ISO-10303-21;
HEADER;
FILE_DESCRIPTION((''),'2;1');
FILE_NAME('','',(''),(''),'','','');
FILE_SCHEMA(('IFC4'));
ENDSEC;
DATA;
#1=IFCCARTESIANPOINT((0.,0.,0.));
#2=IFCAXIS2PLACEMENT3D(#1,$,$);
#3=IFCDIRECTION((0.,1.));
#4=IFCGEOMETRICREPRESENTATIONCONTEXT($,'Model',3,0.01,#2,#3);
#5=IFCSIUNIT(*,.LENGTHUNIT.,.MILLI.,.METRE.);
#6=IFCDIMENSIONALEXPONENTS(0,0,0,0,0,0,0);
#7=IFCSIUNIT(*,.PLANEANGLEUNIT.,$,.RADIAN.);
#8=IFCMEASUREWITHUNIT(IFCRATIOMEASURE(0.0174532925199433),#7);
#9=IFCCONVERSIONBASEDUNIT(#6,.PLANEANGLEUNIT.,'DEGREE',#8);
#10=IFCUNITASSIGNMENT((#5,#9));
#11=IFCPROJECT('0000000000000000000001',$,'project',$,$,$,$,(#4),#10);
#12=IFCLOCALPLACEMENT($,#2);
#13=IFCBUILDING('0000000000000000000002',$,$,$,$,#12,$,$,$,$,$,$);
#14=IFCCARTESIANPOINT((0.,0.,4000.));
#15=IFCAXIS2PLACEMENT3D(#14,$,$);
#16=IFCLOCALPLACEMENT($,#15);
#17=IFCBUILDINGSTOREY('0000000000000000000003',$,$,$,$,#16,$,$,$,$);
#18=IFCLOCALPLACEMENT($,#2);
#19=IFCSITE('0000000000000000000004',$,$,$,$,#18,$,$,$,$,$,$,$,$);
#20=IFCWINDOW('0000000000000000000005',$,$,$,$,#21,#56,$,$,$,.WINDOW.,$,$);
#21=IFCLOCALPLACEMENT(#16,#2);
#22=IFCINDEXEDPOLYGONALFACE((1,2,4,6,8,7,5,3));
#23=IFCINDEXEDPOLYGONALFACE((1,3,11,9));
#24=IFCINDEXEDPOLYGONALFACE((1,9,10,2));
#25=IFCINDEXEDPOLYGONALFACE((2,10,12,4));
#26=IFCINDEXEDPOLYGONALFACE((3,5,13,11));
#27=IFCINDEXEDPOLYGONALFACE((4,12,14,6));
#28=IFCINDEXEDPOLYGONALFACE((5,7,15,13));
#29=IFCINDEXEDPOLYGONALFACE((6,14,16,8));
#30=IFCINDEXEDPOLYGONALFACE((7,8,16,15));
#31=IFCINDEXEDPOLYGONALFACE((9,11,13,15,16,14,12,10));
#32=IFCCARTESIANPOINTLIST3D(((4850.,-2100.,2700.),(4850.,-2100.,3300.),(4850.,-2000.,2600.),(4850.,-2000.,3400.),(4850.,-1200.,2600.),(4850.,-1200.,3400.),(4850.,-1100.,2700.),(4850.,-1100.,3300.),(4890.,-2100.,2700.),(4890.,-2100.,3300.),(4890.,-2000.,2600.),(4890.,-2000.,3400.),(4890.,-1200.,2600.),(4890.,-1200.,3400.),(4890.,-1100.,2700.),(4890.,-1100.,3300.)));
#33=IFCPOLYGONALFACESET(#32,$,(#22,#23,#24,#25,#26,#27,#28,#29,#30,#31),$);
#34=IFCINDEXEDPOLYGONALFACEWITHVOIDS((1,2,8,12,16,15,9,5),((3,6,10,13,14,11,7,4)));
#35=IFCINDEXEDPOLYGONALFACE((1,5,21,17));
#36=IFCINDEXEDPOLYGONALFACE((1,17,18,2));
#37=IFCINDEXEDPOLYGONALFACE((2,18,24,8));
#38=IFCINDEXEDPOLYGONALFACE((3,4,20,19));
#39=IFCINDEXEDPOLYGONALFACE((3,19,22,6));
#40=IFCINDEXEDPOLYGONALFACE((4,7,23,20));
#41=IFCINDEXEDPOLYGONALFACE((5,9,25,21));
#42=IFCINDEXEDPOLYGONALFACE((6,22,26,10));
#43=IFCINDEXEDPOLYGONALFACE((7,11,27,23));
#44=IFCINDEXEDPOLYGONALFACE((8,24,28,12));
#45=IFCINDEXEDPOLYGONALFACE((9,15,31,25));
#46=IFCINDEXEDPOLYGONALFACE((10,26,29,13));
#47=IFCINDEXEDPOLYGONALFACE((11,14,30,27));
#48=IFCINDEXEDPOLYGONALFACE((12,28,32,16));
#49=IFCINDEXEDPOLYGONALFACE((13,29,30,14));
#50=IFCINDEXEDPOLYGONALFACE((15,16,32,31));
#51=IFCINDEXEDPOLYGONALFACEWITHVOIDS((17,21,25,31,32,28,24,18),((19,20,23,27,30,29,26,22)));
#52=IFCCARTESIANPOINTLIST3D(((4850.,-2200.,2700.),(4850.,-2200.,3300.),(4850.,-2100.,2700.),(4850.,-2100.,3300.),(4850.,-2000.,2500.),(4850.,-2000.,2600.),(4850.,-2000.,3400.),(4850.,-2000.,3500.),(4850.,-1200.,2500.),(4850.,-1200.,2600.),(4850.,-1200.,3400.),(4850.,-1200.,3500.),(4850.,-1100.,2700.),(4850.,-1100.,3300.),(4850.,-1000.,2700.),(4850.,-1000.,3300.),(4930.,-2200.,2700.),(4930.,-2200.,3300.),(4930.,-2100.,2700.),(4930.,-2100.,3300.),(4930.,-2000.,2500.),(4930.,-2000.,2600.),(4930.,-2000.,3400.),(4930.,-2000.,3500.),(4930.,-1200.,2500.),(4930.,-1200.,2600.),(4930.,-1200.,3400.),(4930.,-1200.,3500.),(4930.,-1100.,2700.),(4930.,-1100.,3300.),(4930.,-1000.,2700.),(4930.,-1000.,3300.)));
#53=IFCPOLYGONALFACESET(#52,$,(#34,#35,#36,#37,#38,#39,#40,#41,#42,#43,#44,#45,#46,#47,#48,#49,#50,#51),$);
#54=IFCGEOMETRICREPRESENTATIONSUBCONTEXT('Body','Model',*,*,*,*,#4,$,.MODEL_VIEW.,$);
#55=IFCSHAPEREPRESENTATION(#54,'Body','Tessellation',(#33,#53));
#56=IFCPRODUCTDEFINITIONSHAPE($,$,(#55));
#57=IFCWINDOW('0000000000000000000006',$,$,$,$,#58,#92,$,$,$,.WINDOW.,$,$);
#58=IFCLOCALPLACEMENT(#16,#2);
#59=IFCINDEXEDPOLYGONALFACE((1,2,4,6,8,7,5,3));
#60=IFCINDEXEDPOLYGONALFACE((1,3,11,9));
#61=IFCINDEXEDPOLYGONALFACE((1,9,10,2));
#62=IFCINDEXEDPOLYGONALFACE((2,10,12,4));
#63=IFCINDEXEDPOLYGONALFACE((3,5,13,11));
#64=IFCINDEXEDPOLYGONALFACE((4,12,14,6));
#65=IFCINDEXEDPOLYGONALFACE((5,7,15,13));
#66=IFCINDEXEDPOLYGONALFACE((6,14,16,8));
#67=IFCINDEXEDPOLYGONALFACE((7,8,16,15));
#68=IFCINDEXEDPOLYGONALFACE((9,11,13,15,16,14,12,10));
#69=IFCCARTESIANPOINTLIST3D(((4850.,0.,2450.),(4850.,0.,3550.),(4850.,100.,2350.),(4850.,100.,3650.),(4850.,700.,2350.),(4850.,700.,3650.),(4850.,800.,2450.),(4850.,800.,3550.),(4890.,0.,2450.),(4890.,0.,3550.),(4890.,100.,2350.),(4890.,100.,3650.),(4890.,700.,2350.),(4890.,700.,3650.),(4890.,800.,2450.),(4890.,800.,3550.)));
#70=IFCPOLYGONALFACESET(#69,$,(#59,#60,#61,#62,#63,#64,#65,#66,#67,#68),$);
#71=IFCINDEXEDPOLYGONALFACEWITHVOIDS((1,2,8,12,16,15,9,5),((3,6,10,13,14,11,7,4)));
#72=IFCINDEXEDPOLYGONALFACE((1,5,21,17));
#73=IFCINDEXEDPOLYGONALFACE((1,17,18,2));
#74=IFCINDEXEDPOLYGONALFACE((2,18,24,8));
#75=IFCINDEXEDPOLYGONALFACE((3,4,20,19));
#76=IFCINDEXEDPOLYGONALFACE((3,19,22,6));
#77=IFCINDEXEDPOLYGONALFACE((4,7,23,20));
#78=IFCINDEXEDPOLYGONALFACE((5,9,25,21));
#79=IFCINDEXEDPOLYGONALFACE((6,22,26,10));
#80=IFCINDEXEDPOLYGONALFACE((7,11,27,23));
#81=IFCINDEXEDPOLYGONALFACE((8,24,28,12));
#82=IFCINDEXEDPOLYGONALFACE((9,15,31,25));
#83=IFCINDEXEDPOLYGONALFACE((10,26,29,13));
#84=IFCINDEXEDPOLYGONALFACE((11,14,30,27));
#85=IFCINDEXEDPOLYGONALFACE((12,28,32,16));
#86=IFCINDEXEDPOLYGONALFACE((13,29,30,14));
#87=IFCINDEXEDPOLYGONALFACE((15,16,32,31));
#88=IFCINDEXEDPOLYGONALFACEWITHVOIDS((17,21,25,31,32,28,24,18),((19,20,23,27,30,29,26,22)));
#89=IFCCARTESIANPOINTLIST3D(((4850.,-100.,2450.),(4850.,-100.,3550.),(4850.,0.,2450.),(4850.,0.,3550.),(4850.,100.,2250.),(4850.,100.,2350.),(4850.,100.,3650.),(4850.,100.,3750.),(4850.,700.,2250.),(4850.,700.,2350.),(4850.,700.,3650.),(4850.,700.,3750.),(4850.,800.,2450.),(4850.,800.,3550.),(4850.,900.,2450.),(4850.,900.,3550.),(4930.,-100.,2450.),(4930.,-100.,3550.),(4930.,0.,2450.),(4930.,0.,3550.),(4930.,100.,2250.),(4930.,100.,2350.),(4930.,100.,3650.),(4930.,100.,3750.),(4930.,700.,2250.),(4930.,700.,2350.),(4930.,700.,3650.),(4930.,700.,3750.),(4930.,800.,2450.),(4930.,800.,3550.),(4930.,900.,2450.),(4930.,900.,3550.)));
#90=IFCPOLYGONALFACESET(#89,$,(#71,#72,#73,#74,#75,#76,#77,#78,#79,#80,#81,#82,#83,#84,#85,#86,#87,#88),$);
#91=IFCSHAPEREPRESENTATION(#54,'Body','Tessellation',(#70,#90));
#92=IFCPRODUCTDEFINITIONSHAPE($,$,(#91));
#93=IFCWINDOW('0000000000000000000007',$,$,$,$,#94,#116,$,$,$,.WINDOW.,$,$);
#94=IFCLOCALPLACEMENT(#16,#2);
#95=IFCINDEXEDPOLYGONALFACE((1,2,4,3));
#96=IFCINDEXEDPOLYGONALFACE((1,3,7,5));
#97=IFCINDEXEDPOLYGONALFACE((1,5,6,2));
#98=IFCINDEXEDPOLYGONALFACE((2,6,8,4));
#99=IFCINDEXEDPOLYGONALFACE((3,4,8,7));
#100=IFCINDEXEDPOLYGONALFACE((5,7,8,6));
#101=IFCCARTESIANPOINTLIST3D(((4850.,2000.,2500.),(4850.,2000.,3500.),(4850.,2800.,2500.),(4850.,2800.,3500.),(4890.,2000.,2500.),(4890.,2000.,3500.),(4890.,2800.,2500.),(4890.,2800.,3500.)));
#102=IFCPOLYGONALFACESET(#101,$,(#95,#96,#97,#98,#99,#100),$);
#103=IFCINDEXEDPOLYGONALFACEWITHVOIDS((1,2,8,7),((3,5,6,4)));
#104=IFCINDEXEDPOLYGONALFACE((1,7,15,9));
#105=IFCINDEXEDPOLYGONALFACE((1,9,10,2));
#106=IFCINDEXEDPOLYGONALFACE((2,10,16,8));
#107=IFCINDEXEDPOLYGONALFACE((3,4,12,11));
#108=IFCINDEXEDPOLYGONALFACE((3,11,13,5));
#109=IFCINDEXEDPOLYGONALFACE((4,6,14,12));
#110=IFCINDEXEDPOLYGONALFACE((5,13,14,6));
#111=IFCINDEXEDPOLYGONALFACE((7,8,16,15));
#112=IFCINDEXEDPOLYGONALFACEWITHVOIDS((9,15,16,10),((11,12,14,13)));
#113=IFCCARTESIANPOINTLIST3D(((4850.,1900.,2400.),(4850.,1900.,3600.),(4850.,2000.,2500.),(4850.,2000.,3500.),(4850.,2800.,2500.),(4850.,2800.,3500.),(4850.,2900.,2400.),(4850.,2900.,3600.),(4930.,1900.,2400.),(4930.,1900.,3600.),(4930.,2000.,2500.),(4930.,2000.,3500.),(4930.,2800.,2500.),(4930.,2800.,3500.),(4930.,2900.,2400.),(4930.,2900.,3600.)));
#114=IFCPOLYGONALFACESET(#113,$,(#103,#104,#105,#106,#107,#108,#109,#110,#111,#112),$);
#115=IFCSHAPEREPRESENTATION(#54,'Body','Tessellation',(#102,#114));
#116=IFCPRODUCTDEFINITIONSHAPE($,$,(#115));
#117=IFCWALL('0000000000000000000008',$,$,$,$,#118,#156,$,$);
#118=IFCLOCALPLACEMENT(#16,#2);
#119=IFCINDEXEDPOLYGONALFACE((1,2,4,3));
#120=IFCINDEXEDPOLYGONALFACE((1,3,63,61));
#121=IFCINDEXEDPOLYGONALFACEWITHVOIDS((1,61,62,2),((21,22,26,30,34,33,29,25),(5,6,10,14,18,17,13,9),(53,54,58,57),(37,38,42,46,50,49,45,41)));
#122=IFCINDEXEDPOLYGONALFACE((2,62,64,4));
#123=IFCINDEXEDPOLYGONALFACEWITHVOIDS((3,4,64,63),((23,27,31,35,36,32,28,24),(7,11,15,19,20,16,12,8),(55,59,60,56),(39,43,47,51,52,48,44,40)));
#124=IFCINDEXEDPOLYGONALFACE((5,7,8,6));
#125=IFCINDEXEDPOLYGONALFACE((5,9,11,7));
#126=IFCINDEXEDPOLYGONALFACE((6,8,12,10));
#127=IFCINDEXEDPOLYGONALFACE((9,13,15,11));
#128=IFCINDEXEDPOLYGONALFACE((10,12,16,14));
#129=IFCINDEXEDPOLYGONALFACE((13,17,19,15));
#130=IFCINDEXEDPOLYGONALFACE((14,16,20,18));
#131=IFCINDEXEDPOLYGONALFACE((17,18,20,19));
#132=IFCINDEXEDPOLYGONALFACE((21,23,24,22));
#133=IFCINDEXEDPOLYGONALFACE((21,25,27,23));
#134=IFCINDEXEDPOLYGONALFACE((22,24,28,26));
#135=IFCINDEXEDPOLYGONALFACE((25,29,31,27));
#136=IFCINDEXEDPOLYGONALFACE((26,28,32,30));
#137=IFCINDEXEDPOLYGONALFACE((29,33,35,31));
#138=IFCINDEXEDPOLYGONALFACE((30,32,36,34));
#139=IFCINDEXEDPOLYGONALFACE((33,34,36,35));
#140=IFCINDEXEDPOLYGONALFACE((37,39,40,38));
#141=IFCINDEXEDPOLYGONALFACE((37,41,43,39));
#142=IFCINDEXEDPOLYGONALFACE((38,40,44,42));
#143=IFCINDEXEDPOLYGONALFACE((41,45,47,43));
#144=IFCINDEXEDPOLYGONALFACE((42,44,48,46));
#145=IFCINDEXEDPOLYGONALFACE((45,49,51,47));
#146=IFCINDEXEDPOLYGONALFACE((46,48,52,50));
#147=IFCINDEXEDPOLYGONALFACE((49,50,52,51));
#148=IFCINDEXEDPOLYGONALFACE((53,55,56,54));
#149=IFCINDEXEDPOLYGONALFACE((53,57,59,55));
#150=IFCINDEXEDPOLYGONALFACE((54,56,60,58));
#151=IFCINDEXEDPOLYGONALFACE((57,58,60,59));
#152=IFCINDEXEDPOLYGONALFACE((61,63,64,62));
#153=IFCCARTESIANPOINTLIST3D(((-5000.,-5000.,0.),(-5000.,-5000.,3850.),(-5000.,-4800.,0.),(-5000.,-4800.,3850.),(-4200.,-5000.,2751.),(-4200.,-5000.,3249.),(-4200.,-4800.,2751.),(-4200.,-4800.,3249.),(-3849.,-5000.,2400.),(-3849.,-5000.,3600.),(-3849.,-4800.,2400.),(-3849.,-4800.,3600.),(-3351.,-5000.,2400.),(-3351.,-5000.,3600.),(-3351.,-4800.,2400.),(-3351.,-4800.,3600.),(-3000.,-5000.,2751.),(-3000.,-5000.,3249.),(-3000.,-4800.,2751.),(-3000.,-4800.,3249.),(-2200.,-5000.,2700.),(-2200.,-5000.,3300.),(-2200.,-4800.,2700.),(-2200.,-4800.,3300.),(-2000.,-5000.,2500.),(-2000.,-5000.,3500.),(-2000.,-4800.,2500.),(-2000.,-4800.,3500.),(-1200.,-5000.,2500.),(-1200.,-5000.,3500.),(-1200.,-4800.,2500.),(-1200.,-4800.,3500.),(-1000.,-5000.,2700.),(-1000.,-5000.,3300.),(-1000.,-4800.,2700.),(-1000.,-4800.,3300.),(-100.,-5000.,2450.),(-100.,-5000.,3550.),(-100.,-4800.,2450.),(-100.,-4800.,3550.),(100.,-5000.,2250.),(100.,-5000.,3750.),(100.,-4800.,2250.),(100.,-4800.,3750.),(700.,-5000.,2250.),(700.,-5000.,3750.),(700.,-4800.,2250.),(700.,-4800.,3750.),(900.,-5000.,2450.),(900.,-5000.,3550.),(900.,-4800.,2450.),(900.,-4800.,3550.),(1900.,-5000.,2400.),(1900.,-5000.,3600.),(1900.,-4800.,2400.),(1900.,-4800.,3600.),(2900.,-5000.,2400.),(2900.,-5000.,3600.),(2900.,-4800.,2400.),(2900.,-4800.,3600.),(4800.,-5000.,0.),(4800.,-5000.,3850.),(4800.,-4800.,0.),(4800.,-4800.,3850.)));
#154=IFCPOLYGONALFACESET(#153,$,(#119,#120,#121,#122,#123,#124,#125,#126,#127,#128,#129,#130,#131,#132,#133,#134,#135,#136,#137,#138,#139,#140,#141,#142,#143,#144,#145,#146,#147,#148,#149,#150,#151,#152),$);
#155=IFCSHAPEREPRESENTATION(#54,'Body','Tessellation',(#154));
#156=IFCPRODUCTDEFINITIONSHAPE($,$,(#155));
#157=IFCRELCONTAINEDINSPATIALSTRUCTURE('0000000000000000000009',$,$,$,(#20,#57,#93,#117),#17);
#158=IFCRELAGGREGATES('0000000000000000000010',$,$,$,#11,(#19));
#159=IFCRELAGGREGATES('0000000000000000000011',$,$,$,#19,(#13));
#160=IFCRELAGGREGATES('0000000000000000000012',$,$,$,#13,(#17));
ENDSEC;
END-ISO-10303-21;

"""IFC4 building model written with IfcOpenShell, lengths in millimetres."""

from ifc_helpers import new_model, entity, si_unit, converted_unit, direction, frame, origin, origin_2d, place, context, subcontext, project, spatial, polyline, rectangle, outline, extrude, element, save


model = new_model("IFC4")

# Units and contexts
model_context = context("Model", 3, precision=0.01, world=origin(), true_north=direction((0.0, 1.0)))
body_context = subcontext(model_context, "Body", "Model", "MODEL_VIEW")
ifc_project = project(units=[si_unit("LENGTHUNIT", "METRE", prefix="MILLI"), converted_unit("PLANEANGLEUNIT", "DEGREE", entity("IfcRatioMeasure", 0.0174532925199433), si_unit("PLANEANGLEUNIT", "RADIAN"), dimensions=[0, 0, 0, 0, 0, 0, 0])], contexts=[model_context])

# Site, building, storey
site_placement = place(None, origin())
site = spatial("IfcSite", under=ifc_project, at=site_placement)
building_placement = place(None, origin())
building = spatial("IfcBuilding", under=site, at=building_placement)
storey_placement = place(None, frame((0.0, 0.0, 4000.0)))
storey = spatial("IfcBuildingStorey", under=building, at=storey_placement)

# Shared definitions
cartesian_point_1 = entity("IfcCartesianPoint", [-500.0, -300.0])
shared_polyline_1 = entity("IfcPolyline", [cartesian_point_1, entity("IfcCartesianPoint", [-500.0, 300.0]), entity("IfcCartesianPoint", [-400.0, 400.0]), entity("IfcCartesianPoint", [400.0, 400.0]), entity("IfcCartesianPoint", [500.0, 300.0]), entity("IfcCartesianPoint", [500.0, -300.0]), entity("IfcCartesianPoint", [400.0, -400.0]), entity("IfcCartesianPoint", [-400.0, -400.0]), cartesian_point_1])
cartesian_point_2 = entity("IfcCartesianPoint", [-400.0, -550.0])
shared_polyline_2 = entity("IfcPolyline", [cartesian_point_2, entity("IfcCartesianPoint", [-400.0, 550.0]), entity("IfcCartesianPoint", [-300.0, 650.0]), entity("IfcCartesianPoint", [300.0, 650.0]), entity("IfcCartesianPoint", [400.0, 550.0]), entity("IfcCartesianPoint", [400.0, -550.0]), entity("IfcCartesianPoint", [300.0, -650.0]), entity("IfcCartesianPoint", [-300.0, -650.0]), cartesian_point_2])
cartesian_point_3 = entity("IfcCartesianPoint", [-400.0, -500.0])
shared_polyline_3 = entity("IfcPolyline", [cartesian_point_3, entity("IfcCartesianPoint", [-400.0, 500.0]), entity("IfcCartesianPoint", [-400.0, 500.0]), entity("IfcCartesianPoint", [400.0, 500.0]), entity("IfcCartesianPoint", [400.0, 500.0]), entity("IfcCartesianPoint", [400.0, -500.0]), entity("IfcCartesianPoint", [400.0, -500.0]), entity("IfcCartesianPoint", [-400.0, -500.0]), cartesian_point_3])

# Shared definitions
wall_1_placement = place(storey_placement, frame((4900.0, -100.0, 0.0), z_axis=(0.0, 0.0, 1.0), x_axis=(0.0, 1.0, 0.0)))
window_1_placement = place(wall_1_placement, frame((-1500.0, 50.0, 3000.0)))
window_2_placement = place(wall_1_placement, frame((500.0, 50.0, 3000.0)))
window_3_placement = place(wall_1_placement, frame((2500.0, 50.0, 3000.0)))

# Windows
cartesian_point_4 = entity("IfcCartesianPoint", [-600.0, -300.0])
element("IfcWindow", 1, at=window_1_placement, inside=storey, PredefinedType="WINDOW", context=body_context, shape_type="SweptSolid", body=[
    entity("IfcExtrudedAreaSolid", entity("IfcArbitraryClosedProfileDef", "AREA", None, shared_polyline_1), entity("IfcAxis2Placement3D", entity("IfcCartesianPoint", [0.0, 0.0, 0.0]), entity("IfcDirection", [0.0, -1.0, 0.0]), entity("IfcDirection", [1.0, 0.0, 0.0])), entity("IfcDirection", [0.0, 0.0, 1.0]), 40.0),
    entity("IfcExtrudedAreaSolid", entity("IfcArbitraryProfileDefWithVoids", "AREA", None, entity("IfcPolyline", [cartesian_point_4, entity("IfcCartesianPoint", [-600.0, 300.0]), entity("IfcCartesianPoint", [-400.0, 500.0]), entity("IfcCartesianPoint", [400.0, 500.0]), entity("IfcCartesianPoint", [600.0, 300.0]), entity("IfcCartesianPoint", [600.0, -300.0]), entity("IfcCartesianPoint", [400.0, -500.0]), entity("IfcCartesianPoint", [-400.0, -500.0]), cartesian_point_4]), [shared_polyline_1]), entity("IfcAxis2Placement3D", entity("IfcCartesianPoint", [0.0, 0.0, 0.0]), entity("IfcDirection", [0.0, -1.0, 0.0]), entity("IfcDirection", [1.0, 0.0, 0.0])), entity("IfcDirection", [0.0, 0.0, 1.0]), 80.0),
])
cartesian_point_5 = entity("IfcCartesianPoint", [-500.0, -550.0])
element("IfcWindow", 2, at=window_2_placement, inside=storey, PredefinedType="WINDOW", context=body_context, shape_type="SweptSolid", body=[
    entity("IfcExtrudedAreaSolid", entity("IfcArbitraryClosedProfileDef", "AREA", None, shared_polyline_2), entity("IfcAxis2Placement3D", entity("IfcCartesianPoint", [0.0, 0.0, 0.0]), entity("IfcDirection", [0.0, -1.0, 0.0]), entity("IfcDirection", [1.0, 0.0, 0.0])), entity("IfcDirection", [0.0, 0.0, 1.0]), 40.0),
    entity("IfcExtrudedAreaSolid", entity("IfcArbitraryProfileDefWithVoids", "AREA", None, entity("IfcPolyline", [cartesian_point_5, entity("IfcCartesianPoint", [-500.0, 550.0]), entity("IfcCartesianPoint", [-300.0, 750.0]), entity("IfcCartesianPoint", [300.0, 750.0]), entity("IfcCartesianPoint", [500.0, 550.0]), entity("IfcCartesianPoint", [500.0, -550.0]), entity("IfcCartesianPoint", [300.0, -750.0]), entity("IfcCartesianPoint", [-300.0, -750.0]), cartesian_point_5]), [shared_polyline_2]), entity("IfcAxis2Placement3D", entity("IfcCartesianPoint", [0.0, 0.0, 0.0]), entity("IfcDirection", [0.0, -1.0, 0.0]), entity("IfcDirection", [1.0, 0.0, 0.0])), entity("IfcDirection", [0.0, 0.0, 1.0]), 80.0),
])
cartesian_point_6 = entity("IfcCartesianPoint", [-500.0, -600.0])
element("IfcWindow", 3, at=window_3_placement, inside=storey, PredefinedType="WINDOW", context=body_context, shape_type="SweptSolid", body=[
    entity("IfcExtrudedAreaSolid", entity("IfcArbitraryClosedProfileDef", "AREA", None, shared_polyline_3), entity("IfcAxis2Placement3D", entity("IfcCartesianPoint", [0.0, 0.0, 0.0]), entity("IfcDirection", [0.0, -1.0, 0.0]), entity("IfcDirection", [1.0, 0.0, 0.0])), entity("IfcDirection", [0.0, 0.0, 1.0]), 40.0),
    entity("IfcExtrudedAreaSolid", entity("IfcArbitraryProfileDefWithVoids", "AREA", None, entity("IfcPolyline", [cartesian_point_6, entity("IfcCartesianPoint", [-500.0, 600.0]), entity("IfcCartesianPoint", [-500.0, 600.0]), entity("IfcCartesianPoint", [500.0, 600.0]), entity("IfcCartesianPoint", [500.0, 600.0]), entity("IfcCartesianPoint", [500.0, -600.0]), entity("IfcCartesianPoint", [500.0, -600.0]), entity("IfcCartesianPoint", [-500.0, -600.0]), cartesian_point_6]), [shared_polyline_3]), entity("IfcAxis2Placement3D", entity("IfcCartesianPoint", [0.0, 0.0, 0.0]), entity("IfcDirection", [0.0, -1.0, 0.0]), entity("IfcDirection", [1.0, 0.0, 0.0])), entity("IfcDirection", [0.0, 0.0, 1.0]), 80.0),
])

# Wall, openings
wall_2_placement = place(storey_placement, frame((-100.0, -4900.0, 0.0), z_axis=(0.0, 0.0, 1.0), x_axis=(1.0, 0.0, 0.0)))
wall_2 = element("IfcWall", 4, at=wall_2_placement, inside=storey, context=body_context, shape_type="SweptSolid", body=[
    extrude(rectangle(XDim=9800.0, YDim=200.0, at=origin_2d()), origin(), (0.0, 0.0, 1.0), 3850.0),
])
window_4_placement = place(wall_2_placement, frame((-3500.0, 50.0, 3000.0)))
opening_1_placement = place(window_4_placement, frame((0.0, 50.0, 0.0)))
element("IfcOpeningElement", 5, at=opening_1_placement, cuts=wall_2, context=body_context, shape_type="SweptSolid", body=[
    extrude(outline(polyline([(-600.0, -249.0), (-600.0, 249.0), (-249.0, 600.0), (249.0, 600.0), (600.0, 249.0), (600.0, -249.0), (249.0, -600.0), (-249.0, -600.0), (-600.0, -249.0)])), frame((0.0, 0.0, 0.0), z_axis=(0.0, -1.0, 0.0), x_axis=(1.0, 0.0, 0.0)), (0.0, 0.0, 1.0), 200.0),
])
window_5_placement = place(wall_2_placement, frame((-1500.0, 50.0, 3000.0)))
opening_2_placement = place(window_5_placement, frame((0.0, 50.0, 0.0)))
element("IfcOpeningElement", 6, at=opening_2_placement, cuts=wall_2, context=body_context, shape_type="SweptSolid", body=[
    extrude(outline(polyline([(-600.0, -300.0), (-600.0, 300.0), (-400.0, 500.0), (400.0, 500.0), (600.0, 300.0), (600.0, -300.0), (400.0, -500.0), (-400.0, -500.0), (-600.0, -300.0)])), frame((0.0, 0.0, 0.0), z_axis=(0.0, -1.0, 0.0), x_axis=(1.0, 0.0, 0.0)), (0.0, 0.0, 1.0), 200.0),
])
window_6_placement = place(wall_2_placement, frame((500.0, 50.0, 3000.0)))
opening_3_placement = place(window_6_placement, frame((0.0, 50.0, 0.0)))
element("IfcOpeningElement", 7, at=opening_3_placement, cuts=wall_2, context=body_context, shape_type="SweptSolid", body=[
    extrude(outline(polyline([(-500.0, -550.0), (-500.0, 550.0), (-300.0, 750.0), (300.0, 750.0), (500.0, 550.0), (500.0, -550.0), (300.0, -750.0), (-300.0, -750.0), (-500.0, -550.0)])), frame((0.0, 0.0, 0.0), z_axis=(0.0, -1.0, 0.0), x_axis=(1.0, 0.0, 0.0)), (0.0, 0.0, 1.0), 200.0),
])
window_7_placement = place(wall_2_placement, frame((2500.0, 50.0, 3000.0)))
opening_4_placement = place(window_7_placement, frame((0.0, 50.0, 0.0)))
element("IfcOpeningElement", 8, at=opening_4_placement, cuts=wall_2, context=body_context, shape_type="SweptSolid", body=[
    extrude(outline(polyline([(-500.0, -600.0), (-500.0, 600.0), (-500.0, 600.0), (500.0, 600.0), (500.0, 600.0), (500.0, -600.0), (500.0, -600.0), (-500.0, -600.0), (-500.0, -600.0)])), frame((0.0, 0.0, 0.0), z_axis=(0.0, -1.0, 0.0), x_axis=(1.0, 0.0, 0.0)), (0.0, 0.0, 1.0), 200.0),
])

save(model, "model.ifc")
